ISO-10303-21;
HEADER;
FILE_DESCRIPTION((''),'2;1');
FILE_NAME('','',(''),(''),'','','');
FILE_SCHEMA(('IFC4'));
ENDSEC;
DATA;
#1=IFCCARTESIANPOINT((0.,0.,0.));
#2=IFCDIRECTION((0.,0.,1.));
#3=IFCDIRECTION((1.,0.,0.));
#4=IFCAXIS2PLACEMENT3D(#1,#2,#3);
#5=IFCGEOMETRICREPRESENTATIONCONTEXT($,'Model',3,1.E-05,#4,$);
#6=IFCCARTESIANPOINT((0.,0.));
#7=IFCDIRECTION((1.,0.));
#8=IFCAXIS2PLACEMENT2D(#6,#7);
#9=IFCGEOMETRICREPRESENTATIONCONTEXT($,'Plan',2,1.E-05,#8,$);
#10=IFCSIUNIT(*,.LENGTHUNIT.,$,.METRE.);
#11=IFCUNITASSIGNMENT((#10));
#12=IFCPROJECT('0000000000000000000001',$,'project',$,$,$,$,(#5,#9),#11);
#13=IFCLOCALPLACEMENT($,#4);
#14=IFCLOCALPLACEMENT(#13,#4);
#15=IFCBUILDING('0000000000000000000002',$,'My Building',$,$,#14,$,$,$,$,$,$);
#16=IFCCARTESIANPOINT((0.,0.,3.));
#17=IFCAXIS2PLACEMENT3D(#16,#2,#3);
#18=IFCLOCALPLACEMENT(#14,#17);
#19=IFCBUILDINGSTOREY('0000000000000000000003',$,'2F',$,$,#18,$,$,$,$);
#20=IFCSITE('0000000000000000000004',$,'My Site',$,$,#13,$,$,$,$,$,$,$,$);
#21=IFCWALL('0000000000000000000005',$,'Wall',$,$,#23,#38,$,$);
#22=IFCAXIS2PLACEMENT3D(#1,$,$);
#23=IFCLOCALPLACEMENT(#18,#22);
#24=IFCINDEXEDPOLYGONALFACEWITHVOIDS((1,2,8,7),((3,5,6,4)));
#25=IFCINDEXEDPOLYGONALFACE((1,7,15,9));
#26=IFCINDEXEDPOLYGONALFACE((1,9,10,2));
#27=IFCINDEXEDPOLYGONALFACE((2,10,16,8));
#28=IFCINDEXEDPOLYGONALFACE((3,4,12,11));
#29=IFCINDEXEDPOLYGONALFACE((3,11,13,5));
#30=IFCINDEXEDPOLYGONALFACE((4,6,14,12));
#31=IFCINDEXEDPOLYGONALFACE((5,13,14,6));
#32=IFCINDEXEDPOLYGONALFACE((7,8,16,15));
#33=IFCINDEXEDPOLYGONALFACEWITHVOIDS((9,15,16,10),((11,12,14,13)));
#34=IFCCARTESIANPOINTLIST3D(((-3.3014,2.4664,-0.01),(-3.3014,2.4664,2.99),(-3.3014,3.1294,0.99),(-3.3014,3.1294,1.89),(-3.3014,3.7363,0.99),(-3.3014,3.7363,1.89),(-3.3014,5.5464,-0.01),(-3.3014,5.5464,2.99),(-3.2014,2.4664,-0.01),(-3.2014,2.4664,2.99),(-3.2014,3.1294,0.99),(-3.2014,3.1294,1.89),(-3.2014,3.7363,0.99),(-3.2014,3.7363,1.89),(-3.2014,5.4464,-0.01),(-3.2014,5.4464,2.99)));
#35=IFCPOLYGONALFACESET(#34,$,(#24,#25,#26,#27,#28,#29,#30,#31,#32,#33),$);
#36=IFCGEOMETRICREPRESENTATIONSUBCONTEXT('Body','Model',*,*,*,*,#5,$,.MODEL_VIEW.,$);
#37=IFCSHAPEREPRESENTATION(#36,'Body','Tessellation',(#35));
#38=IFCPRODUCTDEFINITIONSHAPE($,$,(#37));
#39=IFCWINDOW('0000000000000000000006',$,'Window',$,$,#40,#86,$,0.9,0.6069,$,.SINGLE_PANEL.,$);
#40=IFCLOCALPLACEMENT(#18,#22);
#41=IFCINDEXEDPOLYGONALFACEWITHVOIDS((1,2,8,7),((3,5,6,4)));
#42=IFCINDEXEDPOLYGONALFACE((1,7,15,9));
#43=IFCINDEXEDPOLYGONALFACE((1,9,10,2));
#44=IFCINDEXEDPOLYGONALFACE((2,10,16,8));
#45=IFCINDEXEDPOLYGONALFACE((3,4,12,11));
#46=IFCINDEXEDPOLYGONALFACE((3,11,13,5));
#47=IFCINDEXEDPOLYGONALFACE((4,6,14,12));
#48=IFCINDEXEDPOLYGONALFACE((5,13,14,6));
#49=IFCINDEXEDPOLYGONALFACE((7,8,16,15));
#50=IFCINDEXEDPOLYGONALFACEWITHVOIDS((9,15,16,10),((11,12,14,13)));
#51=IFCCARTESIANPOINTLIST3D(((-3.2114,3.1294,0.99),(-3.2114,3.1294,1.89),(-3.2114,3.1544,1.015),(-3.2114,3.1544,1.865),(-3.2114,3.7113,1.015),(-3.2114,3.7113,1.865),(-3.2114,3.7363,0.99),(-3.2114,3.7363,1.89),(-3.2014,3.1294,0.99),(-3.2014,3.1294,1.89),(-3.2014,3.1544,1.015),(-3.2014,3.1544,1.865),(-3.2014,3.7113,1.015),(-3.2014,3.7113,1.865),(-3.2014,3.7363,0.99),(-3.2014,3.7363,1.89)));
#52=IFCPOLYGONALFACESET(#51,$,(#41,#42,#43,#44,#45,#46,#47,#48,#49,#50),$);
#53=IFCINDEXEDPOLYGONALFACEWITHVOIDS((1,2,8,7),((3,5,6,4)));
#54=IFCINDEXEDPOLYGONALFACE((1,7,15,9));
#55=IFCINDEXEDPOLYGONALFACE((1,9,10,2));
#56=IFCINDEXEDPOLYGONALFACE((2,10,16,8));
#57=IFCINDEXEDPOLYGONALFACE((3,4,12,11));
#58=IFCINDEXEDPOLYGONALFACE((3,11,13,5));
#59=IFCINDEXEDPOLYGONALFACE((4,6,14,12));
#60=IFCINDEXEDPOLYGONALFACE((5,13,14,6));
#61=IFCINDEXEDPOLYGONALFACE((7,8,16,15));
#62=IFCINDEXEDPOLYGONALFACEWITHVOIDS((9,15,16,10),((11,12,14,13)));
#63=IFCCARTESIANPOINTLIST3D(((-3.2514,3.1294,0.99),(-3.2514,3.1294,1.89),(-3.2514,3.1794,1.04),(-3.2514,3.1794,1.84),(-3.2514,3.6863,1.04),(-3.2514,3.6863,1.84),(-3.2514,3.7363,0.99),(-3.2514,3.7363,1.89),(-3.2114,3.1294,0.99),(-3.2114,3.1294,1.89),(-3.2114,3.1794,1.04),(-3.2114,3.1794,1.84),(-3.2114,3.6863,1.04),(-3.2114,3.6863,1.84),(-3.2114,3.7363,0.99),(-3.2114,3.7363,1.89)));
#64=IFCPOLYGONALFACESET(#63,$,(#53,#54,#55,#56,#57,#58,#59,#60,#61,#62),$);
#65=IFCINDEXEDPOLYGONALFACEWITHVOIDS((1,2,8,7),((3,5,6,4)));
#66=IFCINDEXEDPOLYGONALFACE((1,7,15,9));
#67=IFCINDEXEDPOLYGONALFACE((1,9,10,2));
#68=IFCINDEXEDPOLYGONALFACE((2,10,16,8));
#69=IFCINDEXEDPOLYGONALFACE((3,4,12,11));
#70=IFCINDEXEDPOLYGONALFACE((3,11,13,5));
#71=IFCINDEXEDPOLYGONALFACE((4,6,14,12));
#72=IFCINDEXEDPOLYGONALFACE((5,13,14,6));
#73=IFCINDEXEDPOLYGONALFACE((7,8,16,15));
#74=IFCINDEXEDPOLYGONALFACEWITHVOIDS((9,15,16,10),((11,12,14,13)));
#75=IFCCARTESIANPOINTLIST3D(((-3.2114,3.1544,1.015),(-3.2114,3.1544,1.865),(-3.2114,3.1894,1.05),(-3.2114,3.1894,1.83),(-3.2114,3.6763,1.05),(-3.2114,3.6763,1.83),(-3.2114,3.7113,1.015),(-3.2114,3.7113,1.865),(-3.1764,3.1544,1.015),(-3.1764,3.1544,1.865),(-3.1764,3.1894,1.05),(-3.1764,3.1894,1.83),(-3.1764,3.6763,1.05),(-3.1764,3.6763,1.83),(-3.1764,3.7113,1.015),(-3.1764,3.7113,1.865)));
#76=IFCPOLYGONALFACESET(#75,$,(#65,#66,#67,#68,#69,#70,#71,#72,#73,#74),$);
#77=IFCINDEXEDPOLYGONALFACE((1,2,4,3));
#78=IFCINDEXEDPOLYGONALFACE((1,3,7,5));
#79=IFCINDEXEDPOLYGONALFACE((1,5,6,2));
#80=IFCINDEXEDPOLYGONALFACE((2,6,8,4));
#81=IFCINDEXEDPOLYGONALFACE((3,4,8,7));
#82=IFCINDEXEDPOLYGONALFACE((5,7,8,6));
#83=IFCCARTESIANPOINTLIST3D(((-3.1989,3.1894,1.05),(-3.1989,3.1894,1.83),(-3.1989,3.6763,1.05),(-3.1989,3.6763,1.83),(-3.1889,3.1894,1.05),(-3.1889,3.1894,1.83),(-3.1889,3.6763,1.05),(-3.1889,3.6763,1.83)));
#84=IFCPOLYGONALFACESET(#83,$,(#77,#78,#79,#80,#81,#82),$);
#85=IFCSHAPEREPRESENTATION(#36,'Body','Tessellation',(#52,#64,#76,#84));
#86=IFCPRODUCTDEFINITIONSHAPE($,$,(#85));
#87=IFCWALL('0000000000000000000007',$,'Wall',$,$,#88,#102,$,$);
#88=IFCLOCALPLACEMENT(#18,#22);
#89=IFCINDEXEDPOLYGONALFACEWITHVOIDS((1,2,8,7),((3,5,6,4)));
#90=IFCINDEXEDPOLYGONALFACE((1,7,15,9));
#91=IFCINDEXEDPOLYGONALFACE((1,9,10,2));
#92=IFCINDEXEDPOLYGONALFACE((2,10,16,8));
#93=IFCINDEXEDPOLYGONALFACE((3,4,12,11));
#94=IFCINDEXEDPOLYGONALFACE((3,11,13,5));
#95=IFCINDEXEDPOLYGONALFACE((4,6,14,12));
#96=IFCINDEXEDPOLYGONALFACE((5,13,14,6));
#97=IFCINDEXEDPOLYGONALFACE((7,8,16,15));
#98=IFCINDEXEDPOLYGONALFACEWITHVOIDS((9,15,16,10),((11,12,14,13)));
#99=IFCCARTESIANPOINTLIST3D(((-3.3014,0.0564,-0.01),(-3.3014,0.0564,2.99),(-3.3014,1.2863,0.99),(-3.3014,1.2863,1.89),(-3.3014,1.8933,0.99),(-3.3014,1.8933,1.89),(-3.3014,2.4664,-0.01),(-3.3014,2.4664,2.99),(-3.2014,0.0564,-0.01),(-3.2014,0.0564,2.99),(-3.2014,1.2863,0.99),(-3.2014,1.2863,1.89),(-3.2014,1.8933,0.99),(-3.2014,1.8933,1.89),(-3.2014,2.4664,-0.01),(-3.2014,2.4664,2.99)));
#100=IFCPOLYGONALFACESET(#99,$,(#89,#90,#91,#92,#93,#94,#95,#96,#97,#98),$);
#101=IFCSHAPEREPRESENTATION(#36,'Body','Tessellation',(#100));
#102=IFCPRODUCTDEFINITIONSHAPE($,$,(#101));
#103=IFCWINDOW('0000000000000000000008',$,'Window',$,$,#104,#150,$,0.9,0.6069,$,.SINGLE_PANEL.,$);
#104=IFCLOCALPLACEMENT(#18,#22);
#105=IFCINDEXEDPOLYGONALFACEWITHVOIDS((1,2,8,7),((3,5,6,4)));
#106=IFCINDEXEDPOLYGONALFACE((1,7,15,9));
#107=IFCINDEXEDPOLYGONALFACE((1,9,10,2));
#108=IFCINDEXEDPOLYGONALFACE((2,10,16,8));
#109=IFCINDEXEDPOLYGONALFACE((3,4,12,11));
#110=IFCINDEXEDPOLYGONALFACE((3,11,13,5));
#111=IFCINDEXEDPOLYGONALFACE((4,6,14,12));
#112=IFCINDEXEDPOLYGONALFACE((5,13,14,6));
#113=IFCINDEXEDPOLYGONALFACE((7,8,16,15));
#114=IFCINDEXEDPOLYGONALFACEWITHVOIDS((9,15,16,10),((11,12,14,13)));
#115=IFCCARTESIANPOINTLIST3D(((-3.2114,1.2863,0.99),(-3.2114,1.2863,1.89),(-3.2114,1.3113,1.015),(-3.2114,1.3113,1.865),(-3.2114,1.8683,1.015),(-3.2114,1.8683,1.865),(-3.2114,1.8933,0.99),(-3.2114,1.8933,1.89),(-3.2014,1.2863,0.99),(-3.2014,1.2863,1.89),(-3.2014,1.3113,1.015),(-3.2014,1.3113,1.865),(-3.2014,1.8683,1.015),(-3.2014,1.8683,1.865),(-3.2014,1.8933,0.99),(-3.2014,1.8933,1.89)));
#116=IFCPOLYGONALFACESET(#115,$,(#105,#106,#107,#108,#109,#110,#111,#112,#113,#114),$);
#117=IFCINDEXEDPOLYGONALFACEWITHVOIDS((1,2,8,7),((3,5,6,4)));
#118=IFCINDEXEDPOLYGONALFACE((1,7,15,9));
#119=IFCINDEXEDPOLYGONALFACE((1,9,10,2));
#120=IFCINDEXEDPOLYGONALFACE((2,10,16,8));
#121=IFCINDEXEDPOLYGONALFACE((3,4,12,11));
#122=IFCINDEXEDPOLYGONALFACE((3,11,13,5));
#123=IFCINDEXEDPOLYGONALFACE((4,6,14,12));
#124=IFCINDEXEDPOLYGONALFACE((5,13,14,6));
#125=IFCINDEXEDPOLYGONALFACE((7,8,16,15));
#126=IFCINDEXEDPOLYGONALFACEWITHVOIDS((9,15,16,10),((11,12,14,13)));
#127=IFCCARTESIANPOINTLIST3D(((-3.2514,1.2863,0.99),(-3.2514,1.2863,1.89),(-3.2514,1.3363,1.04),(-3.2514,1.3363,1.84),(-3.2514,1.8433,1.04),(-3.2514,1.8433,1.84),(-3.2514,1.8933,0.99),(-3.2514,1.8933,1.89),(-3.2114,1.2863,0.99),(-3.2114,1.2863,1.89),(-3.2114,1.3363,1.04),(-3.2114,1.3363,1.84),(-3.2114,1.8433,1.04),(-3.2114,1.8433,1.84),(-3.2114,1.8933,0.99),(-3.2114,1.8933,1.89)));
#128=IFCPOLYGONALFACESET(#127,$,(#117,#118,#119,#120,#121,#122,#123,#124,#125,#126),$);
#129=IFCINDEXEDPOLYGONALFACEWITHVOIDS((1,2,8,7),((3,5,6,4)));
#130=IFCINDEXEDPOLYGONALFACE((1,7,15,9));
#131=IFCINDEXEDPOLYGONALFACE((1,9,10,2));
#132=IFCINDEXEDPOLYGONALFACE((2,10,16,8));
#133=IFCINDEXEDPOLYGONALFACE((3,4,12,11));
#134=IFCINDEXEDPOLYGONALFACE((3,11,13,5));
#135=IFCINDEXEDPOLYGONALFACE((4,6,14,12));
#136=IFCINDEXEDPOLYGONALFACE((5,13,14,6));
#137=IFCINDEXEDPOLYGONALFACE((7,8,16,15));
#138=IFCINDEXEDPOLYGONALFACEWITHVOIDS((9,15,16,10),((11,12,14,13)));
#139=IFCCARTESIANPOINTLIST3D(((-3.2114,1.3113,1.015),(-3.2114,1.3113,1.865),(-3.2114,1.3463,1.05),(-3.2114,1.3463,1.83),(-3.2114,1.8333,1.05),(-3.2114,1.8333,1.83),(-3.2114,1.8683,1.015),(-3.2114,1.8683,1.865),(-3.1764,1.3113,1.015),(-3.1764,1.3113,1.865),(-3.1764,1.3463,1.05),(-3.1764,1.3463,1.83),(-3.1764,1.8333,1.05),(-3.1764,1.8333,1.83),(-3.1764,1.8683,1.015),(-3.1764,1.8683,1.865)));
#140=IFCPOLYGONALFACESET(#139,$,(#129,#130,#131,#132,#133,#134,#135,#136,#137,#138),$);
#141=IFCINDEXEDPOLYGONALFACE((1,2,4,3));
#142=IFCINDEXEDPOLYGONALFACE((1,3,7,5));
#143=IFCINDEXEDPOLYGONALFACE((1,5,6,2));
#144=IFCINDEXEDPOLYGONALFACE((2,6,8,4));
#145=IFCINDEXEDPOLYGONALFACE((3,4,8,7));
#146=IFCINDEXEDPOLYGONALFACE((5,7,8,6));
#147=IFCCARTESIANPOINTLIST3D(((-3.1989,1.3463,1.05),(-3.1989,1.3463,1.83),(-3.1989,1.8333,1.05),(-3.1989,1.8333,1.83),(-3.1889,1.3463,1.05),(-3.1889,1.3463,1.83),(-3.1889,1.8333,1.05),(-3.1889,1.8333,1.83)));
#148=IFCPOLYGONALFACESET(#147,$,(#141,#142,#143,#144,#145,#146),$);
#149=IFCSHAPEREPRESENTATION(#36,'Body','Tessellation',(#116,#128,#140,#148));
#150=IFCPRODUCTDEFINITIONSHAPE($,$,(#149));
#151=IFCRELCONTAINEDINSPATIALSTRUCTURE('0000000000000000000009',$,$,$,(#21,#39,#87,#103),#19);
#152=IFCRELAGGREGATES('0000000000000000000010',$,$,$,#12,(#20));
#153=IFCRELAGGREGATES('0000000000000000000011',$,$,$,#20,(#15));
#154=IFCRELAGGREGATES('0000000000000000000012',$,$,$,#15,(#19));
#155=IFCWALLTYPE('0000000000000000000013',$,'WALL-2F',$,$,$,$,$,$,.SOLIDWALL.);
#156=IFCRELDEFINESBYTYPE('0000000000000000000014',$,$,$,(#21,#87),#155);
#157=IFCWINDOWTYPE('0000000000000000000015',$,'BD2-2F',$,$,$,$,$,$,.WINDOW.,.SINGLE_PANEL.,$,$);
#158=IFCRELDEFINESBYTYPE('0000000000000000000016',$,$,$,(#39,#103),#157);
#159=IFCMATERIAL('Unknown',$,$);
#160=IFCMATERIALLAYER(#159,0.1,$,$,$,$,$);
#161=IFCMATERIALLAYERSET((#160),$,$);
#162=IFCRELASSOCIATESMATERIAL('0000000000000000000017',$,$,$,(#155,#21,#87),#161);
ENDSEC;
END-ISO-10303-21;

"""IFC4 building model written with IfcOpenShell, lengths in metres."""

from ifc_helpers import new_model, entity, si_unit, frame, origin_with_axes, origin_2d_with_axis, place, context, subcontext, project, spatial, line, indexed_curve, outline, extrude, shape, source, transform, mapped, material, layer, layer_set, layer_usage, type_object, type_shapes, element, fill, save


model = new_model("IFC4")

# Units and contexts
model_context = context("Model", 3, precision=1e-05, world=origin_with_axes())
plan_context = context("Plan", 2, precision=1e-05, world=origin_2d_with_axis())
body_context_1 = subcontext(model_context, "Body", "Model", "MODEL_VIEW")
body_context_2 = subcontext(plan_context, "Body", "Plan", "PLAN_VIEW")
ifc_project = project(units=[si_unit("LENGTHUNIT", "METRE")], contexts=[model_context, plan_context])

# Site, building, storey
site_placement = place(None, origin_with_axes())
site = spatial("IfcSite", under=ifc_project, at=site_placement, Name="My Site")
building_placement = place(site_placement, origin_with_axes())
building = spatial("IfcBuilding", under=site, at=building_placement, Name="My Building")
storey_placement = place(building_placement, frame((0.0, 0.0, 3.0), z_axis=(0.0, 0.0, 1.0), x_axis=(1.0, 0.0, 0.0)))
storey = spatial("IfcBuildingStorey", under=building, at=storey_placement, Name="2F")

# Shared definitions
ifc_material = material(Name="Unknown")

# Shared definitions
ifc_layer_1 = layer(ifc_material, 0.1)
ifc_layer_set_1 = layer_set([ifc_layer_1])
wall_type_1 = type_object("IfcWallType", Name="WALL-2F", PredefinedType="SOLIDWALL", material=ifc_layer_set_1)

# Walls, openings, windows
ifc_layer_usage_1 = layer_usage(ifc_layer_set_1, "AXIS2", "POSITIVE", 0.0)
wall_1_placement = place(storey_placement, frame((-3.3014, 5.5464, -0.01), z_axis=(0.0, 0.0, 1.0), x_axis=(0.0, -1.0, 0.0)))
wall_1 = element("IfcWall", 1, at=wall_1_placement, inside=storey, type_object=wall_type_1, material=ifc_layer_usage_1, Name="Wall", context=body_context_1, shape_type="SweptSolid", body=[
    extrude(outline(indexed_curve([(0.0, 0.0), (0.1, 0.1), (3.08, 0.1), (3.08, 0.0)], segments=[line(1, 2, 3, 4, 1)])), origin_with_axes(), (0.0, 0.0, 1.0), 3.0),
])
shared_shape_1 = source(origin_with_axes(), body_context_1, "Body", "SweptSolid", [
    extrude(outline(indexed_curve([(0.0, 0.0), (0.6069, 0.0), (0.6069, 0.9), (0.0, 0.9)], segments=[line(1, 2, 3, 4, 1)])), frame((0.0, -0.6, 0.0), z_axis=(0.0, -1.0, 0.0), x_axis=(1.0, 0.0, 0.0)), (0.0, 0.0, -1.0), 1.2),
])
opening_1_placement = place(wall_1_placement, frame((1.8101, 0.0, 1.0), z_axis=(0.0, 0.0, 1.0), x_axis=(1.0, 0.0, 0.0)))
opening_1 = element("IfcOpeningElement", 2, at=opening_1_placement, cuts=wall_1, PredefinedType="OPENING", context=body_context_1, shape_type="MappedRepresentation", body=[
    mapped(shared_shape_1, transform((0.0, 0.0, 0.0), x_axis=(1.0, 0.0, 0.0), y_axis=(0.0, 1.0, 0.0), z_axis=(0.0, 0.0, 1.0), scale=1.0)),
])
window_type_1 = type_object("IfcWindowType", Name="BD2-2F", PartitioningType="SINGLE_PANEL", PredefinedType="WINDOW")
shared_shape_2 = source(origin_with_axes(), body_context_1, "Body", "SweptSolid", [
    extrude(outline(indexed_curve([(0.0, 0.0), (0.6069, 0.0), (0.6069, 0.9), (0.0, 0.9)], segments=[line(1, 2, 3, 4, 1)]), holes=[indexed_curve([(0.025, 0.025), (0.5819, 0.025), (0.5819, 0.875), (0.025, 0.875)], segments=[line(1, 2, 3, 4, 1)])]), frame((0.0, 0.09, 0.0), z_axis=(0.0, -1.0, 0.0), x_axis=(1.0, 0.0, 0.0)), (0.0, 0.0, -1.0), 0.01),
    extrude(outline(indexed_curve([(0.0, 0.0), (0.6069, 0.0), (0.6069, 0.9), (0.0, 0.9)], segments=[line(1, 2, 3, 4, 1)]), holes=[indexed_curve([(0.05, 0.05), (0.5569, 0.05), (0.5569, 0.85), (0.05, 0.85)], segments=[line(1, 2, 3, 4, 1)])]), frame((0.0, 0.05, 0.0), z_axis=(0.0, -1.0, 0.0), x_axis=(1.0, 0.0, 0.0)), (0.0, 0.0, -1.0), 0.04),
    extrude(outline(indexed_curve([(0.0, 0.0), (0.5569, 0.0), (0.5569, 0.85), (0.0, 0.85)], segments=[line(1, 2, 3, 4, 1)]), holes=[indexed_curve([(0.035, 0.035), (0.5219, 0.035), (0.5219, 0.815), (0.035, 0.815)], segments=[line(1, 2, 3, 4, 1)])]), frame((0.025, 0.09, 0.025), z_axis=(0.0, -1.0, 0.0), x_axis=(1.0, 0.0, 0.0)), (0.0, 0.0, -1.0), 0.035),
    extrude(outline(indexed_curve([(0.035, 0.035), (0.5219, 0.035), (0.5219, 0.815), (0.035, 0.815)], segments=[line(1, 2, 3, 4, 1)])), frame((0.025, 0.1025, 0.025), z_axis=(0.0, -1.0, 0.0), x_axis=(1.0, 0.0, 0.0)), (0.0, 0.0, -1.0), 0.01),
])
shared_shape_3 = source(origin_with_axes(), body_context_2, "Body", "Curve2D", [
    entity("IfcIndexedPolyCurve", entity("IfcCartesianPointList2D", [[0.05, 0.05], [0.5569, 0.05]])),
    entity("IfcIndexedPolyCurve", entity("IfcCartesianPointList2D", [[0.0, 0.1], [0.025, 0.1], [0.025, 0.09], [0.05, 0.09], [0.05, 0.05], [0.0, 0.05]]), [entity("IfcLineIndex", [1, 2, 3, 4, 5, 6, 1])]),
    entity("IfcIndexedPolyCurve", entity("IfcCartesianPointList2D", [[0.6069, 0.1], [0.5819, 0.1], [0.5819, 0.09], [0.5569, 0.09], [0.5569, 0.05], [0.6069, 0.05]]), [entity("IfcLineIndex", [1, 2, 3, 4, 5, 6, 1])]),
    entity("IfcIndexedPolyCurve", entity("IfcCartesianPointList2D", [[0.025, 0.09], [0.06, 0.09], [0.06, 0.125], [0.025, 0.125]]), [entity("IfcLineIndex", [1, 2, 3, 4, 1])]),
    entity("IfcIndexedPolyCurve", entity("IfcCartesianPointList2D", [[0.5819, 0.09], [0.5469, 0.09], [0.5469, 0.125], [0.5819, 0.125]]), [entity("IfcLineIndex", [1, 2, 3, 4, 1])]),
    entity("IfcIndexedPolyCurve", entity("IfcCartesianPointList2D", [[0.06, 0.09], [0.5469, 0.09]])),
    entity("IfcIndexedPolyCurve", entity("IfcCartesianPointList2D", [[0.06, 0.125], [0.5469, 0.125]])),
    entity("IfcIndexedPolyCurve", entity("IfcCartesianPointList2D", [[0.06, 0.1075], [0.5469, 0.1075]])),
])
type_shapes(window_type_1, [shared_shape_2, shared_shape_3])
window_1_placement = place(opening_1_placement, frame((0.0, 0.0, 0.0), z_axis=(0.0, 0.0, 1.0), x_axis=(1.0, 0.0, 0.0)))
window_1 = element("IfcWindow", 3, at=window_1_placement, inside=storey, type_object=window_type_1, Name="Window", OverallHeight=0.9, OverallWidth=0.6069, PartitioningType="SINGLE_PANEL", shapes=[
    shape(body_context_1, "Body", "MappedRepresentation", [mapped(shared_shape_2, transform((0.0, 0.0, 0.0), x_axis=(1.0, 0.0, 0.0), y_axis=(0.0, 1.0, 0.0), z_axis=(0.0, 0.0, 1.0), scale=1.0))]),
    shape(body_context_2, "Body", "MappedRepresentation", [mapped(shared_shape_3, transform((0.0, 0.0, 0.0), x_axis=(1.0, 0.0, 0.0), y_axis=(0.0, 1.0, 0.0), z_axis=(0.0, 0.0, 1.0), scale=1.0))]),
])
fill(opening_1, window_1)
ifc_layer_usage_2 = layer_usage(ifc_layer_set_1, "AXIS2", "POSITIVE", 0.0)
wall_2_placement = place(storey_placement, frame((-3.3014, 2.4664, -0.01), z_axis=(0.0, 0.0, 1.0), x_axis=(0.0, -1.0, 0.0)))
wall_2 = element("IfcWall", 4, at=wall_2_placement, inside=storey, type_object=wall_type_1, material=ifc_layer_usage_2, Name="Wall", context=body_context_1, shape_type="SweptSolid", body=[
    extrude(outline(indexed_curve([(0.0, 0.0), (0.0, 0.1), (2.41, 0.1), (2.41, 0.0)], segments=[line(1, 2, 3, 4, 1)])), origin_with_axes(), (0.0, 0.0, 1.0), 3.0),
])
opening_2_placement = place(wall_2_placement, frame((0.5731, 0.0, 1.0), z_axis=(0.0, 0.0, 1.0), x_axis=(1.0, 0.0, 0.0)))
opening_2 = element("IfcOpeningElement", 5, at=opening_2_placement, cuts=wall_2, PredefinedType="OPENING", context=body_context_1, shape_type="MappedRepresentation", body=[
    mapped(shared_shape_1, transform((0.0, 0.0, 0.0), x_axis=(1.0, 0.0, 0.0), y_axis=(0.0, 1.0, 0.0), z_axis=(0.0, 0.0, 1.0), scale=1.0)),
])
window_2_placement = place(opening_2_placement, frame((0.0, 0.0, 0.0), z_axis=(0.0, 0.0, 1.0), x_axis=(1.0, 0.0, 0.0)))
window_2 = element("IfcWindow", 6, at=window_2_placement, inside=storey, type_object=window_type_1, Name="Window", OverallHeight=0.9, OverallWidth=0.6069, PartitioningType="SINGLE_PANEL", shapes=[
    shape(body_context_1, "Body", "MappedRepresentation", [mapped(shared_shape_2, transform((0.0, 0.0, 0.0), x_axis=(1.0, 0.0, 0.0), y_axis=(0.0, 1.0, 0.0), z_axis=(0.0, 0.0, 1.0), scale=1.0))]),
    shape(body_context_2, "Body", "MappedRepresentation", [mapped(shared_shape_3, transform((0.0, 0.0, 0.0), x_axis=(1.0, 0.0, 0.0), y_axis=(0.0, 1.0, 0.0), z_axis=(0.0, 0.0, 1.0), scale=1.0))]),
])
fill(opening_2, window_2)

save(model, "model.ifc")
